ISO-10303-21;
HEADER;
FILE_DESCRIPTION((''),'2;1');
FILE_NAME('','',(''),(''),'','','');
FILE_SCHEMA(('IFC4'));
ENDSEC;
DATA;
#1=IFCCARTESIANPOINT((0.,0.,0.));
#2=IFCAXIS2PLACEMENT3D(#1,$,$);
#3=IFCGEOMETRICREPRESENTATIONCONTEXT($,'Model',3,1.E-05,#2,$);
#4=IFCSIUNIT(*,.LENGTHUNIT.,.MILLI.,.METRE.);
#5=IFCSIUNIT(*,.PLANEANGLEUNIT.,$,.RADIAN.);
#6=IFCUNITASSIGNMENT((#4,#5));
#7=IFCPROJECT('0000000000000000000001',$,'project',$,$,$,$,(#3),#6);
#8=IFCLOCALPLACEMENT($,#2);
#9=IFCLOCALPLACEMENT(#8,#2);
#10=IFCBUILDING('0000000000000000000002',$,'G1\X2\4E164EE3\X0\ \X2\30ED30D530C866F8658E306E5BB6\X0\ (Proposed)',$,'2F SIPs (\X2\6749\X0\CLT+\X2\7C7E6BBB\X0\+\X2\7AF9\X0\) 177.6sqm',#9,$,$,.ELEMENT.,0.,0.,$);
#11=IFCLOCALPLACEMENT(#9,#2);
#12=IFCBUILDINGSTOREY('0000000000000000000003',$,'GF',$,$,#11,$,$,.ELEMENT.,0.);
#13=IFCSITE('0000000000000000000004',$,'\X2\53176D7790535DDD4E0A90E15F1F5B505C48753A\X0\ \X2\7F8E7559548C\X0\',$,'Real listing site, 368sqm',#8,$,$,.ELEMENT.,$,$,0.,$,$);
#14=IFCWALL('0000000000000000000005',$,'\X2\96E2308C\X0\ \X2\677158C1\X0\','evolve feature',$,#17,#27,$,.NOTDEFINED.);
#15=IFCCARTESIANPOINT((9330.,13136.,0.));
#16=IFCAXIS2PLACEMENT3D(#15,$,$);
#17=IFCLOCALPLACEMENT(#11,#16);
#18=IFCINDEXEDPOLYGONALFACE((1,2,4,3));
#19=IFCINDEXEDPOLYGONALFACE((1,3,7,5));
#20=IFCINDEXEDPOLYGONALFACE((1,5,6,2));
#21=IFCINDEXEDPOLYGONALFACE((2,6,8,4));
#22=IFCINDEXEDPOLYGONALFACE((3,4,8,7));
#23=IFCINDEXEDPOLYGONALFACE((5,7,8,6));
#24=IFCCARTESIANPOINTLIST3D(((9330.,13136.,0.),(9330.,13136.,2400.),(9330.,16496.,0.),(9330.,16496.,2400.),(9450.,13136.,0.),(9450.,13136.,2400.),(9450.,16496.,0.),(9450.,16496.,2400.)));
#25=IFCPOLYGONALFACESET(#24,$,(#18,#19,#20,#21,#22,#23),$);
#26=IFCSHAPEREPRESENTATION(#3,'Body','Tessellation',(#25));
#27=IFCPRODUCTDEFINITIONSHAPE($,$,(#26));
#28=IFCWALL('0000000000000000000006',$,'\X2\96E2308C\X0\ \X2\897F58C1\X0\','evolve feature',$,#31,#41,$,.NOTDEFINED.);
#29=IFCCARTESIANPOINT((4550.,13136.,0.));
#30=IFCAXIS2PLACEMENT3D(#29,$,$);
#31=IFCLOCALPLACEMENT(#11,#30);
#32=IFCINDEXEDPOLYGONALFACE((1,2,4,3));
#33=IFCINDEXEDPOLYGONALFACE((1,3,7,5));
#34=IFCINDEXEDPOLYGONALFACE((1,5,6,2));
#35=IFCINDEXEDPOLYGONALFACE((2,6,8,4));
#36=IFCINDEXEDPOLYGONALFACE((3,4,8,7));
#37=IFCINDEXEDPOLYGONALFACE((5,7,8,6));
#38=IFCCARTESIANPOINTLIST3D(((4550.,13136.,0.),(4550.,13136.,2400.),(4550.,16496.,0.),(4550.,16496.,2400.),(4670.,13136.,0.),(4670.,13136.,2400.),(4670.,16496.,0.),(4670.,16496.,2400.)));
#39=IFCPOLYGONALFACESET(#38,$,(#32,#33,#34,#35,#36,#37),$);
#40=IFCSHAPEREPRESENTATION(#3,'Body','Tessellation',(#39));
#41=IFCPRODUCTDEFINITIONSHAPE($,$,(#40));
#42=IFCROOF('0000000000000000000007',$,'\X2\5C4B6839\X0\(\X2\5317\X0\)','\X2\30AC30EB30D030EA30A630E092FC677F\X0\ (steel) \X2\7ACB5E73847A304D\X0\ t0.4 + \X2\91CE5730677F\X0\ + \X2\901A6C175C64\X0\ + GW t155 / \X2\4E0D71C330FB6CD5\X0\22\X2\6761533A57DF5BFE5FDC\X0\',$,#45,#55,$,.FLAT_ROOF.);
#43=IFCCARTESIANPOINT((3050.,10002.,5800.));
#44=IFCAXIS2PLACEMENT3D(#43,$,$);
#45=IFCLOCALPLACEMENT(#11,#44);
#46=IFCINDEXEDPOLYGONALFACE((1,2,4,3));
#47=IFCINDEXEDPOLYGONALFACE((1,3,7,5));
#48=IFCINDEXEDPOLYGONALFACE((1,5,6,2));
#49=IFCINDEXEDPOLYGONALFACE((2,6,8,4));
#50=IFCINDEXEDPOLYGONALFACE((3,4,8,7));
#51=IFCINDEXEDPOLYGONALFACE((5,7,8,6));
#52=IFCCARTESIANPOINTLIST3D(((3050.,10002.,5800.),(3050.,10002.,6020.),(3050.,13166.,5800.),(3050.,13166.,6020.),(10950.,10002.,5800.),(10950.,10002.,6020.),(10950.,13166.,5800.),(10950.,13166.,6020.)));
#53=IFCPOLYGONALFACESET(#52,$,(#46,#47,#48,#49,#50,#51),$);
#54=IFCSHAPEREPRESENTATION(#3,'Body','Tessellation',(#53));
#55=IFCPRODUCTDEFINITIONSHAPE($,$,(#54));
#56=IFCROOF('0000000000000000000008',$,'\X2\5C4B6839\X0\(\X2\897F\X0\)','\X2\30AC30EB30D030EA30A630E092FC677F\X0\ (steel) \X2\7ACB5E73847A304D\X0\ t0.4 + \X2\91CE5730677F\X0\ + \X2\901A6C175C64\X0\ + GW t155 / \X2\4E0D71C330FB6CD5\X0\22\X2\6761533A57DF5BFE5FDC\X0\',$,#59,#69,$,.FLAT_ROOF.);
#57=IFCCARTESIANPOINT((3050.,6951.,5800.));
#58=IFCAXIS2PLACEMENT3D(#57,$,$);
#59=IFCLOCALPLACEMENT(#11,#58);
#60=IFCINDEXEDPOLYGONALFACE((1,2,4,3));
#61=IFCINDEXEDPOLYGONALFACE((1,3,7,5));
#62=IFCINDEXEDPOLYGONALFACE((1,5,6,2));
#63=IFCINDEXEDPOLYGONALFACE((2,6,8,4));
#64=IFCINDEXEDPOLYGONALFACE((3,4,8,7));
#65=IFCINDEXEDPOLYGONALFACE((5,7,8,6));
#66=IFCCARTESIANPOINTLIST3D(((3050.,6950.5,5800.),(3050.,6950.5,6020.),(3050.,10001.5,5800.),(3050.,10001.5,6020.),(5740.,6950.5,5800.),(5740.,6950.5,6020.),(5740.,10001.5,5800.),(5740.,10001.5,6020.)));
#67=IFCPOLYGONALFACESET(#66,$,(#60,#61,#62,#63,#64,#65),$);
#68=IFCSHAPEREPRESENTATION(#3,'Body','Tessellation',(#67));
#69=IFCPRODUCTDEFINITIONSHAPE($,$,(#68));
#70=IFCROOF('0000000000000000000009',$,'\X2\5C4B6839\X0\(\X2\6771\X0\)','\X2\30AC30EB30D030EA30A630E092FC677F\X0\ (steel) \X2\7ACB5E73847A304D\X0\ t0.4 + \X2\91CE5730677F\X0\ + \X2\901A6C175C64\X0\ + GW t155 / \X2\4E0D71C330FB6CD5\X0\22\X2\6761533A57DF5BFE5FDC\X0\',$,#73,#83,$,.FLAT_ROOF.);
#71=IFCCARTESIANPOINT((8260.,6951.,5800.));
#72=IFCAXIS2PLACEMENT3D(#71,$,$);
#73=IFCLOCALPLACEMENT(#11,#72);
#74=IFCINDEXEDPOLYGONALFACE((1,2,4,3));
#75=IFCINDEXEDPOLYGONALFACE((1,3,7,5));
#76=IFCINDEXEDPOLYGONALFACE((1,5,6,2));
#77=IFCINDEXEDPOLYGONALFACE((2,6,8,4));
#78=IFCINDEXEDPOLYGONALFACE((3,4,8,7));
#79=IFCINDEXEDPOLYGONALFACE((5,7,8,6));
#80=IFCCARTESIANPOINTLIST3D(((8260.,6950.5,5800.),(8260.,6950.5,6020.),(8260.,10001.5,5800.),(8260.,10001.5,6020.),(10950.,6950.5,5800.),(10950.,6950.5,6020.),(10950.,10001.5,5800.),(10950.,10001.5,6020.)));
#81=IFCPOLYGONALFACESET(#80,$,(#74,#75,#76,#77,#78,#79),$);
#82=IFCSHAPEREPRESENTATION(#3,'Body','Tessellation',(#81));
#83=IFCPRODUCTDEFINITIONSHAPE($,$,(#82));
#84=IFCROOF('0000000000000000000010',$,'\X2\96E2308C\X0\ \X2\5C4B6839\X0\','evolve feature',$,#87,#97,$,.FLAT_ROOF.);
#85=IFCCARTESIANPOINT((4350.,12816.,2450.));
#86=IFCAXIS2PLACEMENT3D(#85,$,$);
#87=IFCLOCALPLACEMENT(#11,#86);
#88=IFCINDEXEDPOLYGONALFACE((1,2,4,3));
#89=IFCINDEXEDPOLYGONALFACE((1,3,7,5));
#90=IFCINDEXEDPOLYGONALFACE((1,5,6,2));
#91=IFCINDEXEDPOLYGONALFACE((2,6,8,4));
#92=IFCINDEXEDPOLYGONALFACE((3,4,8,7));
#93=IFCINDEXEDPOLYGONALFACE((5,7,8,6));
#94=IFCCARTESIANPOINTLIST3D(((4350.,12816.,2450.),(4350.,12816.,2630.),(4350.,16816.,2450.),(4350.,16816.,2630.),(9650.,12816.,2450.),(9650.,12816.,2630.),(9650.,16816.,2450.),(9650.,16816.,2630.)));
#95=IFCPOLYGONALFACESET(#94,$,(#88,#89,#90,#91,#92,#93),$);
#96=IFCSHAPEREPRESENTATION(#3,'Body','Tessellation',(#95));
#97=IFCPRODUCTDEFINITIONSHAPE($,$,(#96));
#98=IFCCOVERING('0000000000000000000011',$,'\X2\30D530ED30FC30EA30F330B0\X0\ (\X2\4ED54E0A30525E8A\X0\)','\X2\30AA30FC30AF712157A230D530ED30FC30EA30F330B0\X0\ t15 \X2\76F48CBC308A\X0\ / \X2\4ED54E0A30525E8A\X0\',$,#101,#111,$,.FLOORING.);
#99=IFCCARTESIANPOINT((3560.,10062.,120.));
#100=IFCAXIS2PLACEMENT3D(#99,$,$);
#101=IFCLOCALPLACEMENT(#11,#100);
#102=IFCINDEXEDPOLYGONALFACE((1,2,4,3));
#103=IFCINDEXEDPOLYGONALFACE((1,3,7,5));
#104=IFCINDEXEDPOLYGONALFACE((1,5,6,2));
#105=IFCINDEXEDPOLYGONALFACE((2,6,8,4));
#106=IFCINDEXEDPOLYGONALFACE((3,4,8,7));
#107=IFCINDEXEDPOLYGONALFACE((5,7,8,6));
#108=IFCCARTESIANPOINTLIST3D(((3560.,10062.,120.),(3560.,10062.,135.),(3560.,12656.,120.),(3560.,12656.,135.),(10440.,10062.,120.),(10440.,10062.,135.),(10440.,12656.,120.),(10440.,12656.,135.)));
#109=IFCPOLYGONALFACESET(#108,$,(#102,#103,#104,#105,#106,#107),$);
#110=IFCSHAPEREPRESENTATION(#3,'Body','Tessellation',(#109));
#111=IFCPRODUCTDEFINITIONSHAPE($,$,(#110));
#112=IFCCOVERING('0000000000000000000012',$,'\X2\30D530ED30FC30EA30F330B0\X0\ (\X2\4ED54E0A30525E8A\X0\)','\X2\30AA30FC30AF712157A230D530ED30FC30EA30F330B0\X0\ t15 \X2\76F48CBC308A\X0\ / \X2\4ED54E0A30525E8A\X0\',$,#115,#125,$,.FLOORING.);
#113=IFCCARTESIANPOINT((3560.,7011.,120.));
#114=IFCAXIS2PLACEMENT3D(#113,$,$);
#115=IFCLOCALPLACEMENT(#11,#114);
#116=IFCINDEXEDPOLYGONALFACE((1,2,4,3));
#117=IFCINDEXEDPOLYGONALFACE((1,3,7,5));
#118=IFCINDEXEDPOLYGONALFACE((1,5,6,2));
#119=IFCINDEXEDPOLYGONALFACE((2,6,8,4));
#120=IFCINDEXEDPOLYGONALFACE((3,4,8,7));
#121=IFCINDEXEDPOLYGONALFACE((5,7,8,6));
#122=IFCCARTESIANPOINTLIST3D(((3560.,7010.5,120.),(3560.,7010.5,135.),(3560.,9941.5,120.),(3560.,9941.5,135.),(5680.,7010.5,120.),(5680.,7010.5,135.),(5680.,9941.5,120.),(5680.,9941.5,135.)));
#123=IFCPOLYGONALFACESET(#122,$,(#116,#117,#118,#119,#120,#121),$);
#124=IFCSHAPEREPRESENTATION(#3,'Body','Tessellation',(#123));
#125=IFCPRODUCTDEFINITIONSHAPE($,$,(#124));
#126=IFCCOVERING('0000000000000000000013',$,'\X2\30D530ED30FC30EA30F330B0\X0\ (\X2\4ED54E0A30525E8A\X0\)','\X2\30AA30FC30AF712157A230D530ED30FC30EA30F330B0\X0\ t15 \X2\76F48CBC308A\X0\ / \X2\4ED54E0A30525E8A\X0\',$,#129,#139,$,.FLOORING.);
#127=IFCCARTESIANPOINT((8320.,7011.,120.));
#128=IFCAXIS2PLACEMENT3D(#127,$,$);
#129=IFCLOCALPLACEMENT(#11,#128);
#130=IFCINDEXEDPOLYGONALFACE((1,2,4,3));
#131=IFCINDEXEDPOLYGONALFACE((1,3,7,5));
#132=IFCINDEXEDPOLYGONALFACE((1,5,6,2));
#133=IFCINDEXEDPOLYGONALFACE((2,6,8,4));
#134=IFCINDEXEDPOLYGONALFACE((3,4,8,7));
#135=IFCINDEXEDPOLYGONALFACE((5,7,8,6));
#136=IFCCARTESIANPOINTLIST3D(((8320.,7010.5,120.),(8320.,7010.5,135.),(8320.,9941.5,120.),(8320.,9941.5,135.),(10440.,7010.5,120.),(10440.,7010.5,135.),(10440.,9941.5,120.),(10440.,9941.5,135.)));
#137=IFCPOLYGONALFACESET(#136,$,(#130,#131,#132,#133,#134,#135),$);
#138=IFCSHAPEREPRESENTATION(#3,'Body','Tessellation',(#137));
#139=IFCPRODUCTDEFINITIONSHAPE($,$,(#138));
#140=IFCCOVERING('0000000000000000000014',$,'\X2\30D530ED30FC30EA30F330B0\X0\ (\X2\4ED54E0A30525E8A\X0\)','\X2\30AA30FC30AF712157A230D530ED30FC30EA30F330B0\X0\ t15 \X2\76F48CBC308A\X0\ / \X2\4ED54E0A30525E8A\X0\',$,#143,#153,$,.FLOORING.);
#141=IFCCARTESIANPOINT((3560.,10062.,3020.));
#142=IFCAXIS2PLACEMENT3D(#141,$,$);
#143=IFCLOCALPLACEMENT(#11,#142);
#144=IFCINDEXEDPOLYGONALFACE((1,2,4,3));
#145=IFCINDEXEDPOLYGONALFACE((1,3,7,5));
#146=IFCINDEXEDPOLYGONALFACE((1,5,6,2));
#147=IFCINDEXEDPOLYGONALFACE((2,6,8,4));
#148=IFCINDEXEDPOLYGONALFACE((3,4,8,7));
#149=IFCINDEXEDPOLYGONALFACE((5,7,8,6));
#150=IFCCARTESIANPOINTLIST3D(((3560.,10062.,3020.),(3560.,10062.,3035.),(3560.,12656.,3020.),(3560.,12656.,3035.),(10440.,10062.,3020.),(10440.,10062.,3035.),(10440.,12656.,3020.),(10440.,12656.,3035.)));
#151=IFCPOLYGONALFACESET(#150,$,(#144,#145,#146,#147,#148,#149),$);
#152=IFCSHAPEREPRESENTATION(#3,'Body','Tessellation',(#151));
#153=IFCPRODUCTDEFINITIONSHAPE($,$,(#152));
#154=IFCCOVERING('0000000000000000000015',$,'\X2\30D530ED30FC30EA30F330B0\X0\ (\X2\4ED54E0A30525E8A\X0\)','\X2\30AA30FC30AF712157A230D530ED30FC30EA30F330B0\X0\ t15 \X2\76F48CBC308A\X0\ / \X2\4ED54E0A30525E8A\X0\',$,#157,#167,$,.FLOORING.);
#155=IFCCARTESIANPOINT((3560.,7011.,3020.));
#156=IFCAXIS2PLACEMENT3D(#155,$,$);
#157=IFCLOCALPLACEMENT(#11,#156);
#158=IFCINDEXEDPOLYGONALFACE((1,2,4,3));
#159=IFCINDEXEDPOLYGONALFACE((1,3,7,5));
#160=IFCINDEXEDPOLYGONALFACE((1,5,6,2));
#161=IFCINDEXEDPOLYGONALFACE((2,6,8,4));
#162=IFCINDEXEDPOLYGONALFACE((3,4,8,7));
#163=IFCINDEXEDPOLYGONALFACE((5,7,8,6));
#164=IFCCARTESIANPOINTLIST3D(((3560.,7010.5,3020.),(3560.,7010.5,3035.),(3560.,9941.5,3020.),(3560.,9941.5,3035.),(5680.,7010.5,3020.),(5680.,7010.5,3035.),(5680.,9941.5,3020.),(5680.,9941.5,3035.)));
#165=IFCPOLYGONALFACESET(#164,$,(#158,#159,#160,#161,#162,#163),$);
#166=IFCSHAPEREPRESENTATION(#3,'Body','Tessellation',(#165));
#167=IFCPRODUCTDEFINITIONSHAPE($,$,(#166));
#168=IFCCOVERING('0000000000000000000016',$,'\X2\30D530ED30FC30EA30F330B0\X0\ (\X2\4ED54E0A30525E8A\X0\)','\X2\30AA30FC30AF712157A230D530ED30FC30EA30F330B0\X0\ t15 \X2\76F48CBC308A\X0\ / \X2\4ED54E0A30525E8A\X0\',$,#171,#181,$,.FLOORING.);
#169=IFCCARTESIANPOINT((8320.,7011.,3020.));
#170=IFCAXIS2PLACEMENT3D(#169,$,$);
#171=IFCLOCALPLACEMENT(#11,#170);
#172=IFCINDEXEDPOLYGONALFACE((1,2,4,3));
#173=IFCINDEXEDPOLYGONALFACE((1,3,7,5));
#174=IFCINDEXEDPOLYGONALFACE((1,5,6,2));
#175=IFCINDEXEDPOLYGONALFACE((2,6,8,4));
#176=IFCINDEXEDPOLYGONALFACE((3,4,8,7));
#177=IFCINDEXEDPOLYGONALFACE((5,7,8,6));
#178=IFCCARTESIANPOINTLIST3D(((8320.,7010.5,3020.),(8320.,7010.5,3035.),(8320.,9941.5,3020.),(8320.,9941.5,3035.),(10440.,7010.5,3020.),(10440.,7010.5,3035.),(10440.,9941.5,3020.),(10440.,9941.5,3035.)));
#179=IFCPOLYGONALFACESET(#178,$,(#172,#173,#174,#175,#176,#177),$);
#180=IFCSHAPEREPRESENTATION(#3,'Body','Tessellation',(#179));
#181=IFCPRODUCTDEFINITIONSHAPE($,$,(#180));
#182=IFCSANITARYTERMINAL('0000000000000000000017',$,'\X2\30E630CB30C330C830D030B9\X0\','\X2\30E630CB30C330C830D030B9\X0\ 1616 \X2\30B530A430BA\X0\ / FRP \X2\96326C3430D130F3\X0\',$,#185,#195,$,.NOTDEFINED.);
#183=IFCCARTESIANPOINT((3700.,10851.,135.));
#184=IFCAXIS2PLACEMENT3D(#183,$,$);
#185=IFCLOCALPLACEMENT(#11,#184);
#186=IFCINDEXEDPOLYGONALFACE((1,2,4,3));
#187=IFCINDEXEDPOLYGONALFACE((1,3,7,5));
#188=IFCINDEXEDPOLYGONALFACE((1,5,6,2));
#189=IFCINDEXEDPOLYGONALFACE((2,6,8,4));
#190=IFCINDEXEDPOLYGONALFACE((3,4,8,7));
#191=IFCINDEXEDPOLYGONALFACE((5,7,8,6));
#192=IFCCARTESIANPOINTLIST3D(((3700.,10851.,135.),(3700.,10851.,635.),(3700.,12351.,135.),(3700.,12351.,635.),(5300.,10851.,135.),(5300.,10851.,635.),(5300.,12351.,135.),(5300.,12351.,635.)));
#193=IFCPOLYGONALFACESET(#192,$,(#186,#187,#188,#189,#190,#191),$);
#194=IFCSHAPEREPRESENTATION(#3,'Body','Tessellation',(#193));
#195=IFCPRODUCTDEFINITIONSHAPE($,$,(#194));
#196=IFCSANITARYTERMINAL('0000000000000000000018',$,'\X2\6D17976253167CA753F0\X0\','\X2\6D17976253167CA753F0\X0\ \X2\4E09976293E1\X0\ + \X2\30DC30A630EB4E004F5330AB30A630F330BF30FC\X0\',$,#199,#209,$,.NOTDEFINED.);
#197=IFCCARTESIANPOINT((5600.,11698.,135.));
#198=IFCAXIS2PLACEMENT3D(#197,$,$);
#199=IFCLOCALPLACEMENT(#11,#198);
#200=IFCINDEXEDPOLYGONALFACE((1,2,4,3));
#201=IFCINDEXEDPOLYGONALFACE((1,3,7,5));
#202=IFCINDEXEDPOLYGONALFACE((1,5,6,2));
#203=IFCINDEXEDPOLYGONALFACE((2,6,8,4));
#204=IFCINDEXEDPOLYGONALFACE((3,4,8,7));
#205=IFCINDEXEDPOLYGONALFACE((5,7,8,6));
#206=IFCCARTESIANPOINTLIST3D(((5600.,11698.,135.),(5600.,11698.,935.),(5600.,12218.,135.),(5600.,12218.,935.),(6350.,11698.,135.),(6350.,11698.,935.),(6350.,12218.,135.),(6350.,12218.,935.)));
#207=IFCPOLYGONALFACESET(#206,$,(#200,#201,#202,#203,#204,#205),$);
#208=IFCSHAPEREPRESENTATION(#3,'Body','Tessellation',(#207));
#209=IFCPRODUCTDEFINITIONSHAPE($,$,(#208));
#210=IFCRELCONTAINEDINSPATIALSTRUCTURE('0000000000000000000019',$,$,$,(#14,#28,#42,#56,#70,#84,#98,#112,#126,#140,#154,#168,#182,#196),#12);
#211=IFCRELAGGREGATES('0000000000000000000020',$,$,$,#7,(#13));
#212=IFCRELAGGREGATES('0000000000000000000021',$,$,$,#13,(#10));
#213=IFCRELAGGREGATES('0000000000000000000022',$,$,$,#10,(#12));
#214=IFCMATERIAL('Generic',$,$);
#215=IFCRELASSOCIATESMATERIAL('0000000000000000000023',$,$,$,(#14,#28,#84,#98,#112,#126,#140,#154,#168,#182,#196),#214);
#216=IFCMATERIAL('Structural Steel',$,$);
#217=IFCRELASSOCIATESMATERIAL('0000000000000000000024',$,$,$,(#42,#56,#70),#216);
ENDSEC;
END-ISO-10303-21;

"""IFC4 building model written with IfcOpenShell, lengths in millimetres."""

from ifc_helpers import new_model, si_unit, frame, frame_2d, origin, place, context, project, spatial, rectangle, extrude, material, element, save


model = new_model("IFC4")

# Units and contexts
model_context = context("Model", 3, precision=1e-05, world=origin())
ifc_project = project(units=[si_unit("LENGTHUNIT", "METRE", prefix="MILLI"), si_unit("PLANEANGLEUNIT", "RADIAN")], contexts=[model_context])

# Site, building, storey
site_placement = place(None, origin())
site = spatial("IfcSite", under=ifc_project, at=site_placement, Name="北海道川上郡弟子屈町 美留和", ObjectType="Real listing site, 368sqm", CompositionType="ELEMENT", RefElevation=0.0)
building_placement = place(site_placement, origin())
building = spatial("IfcBuilding", under=site, at=building_placement, Name="G1世代 ロフト書斎の家 (Proposed)", ObjectType="2F SIPs (杉CLT+籾殻+竹) 177.6sqm", CompositionType="ELEMENT", ElevationOfRefHeight=0.0, ElevationOfTerrain=0.0)
storey_placement = place(building_placement, origin())
storey = spatial("IfcBuildingStorey", under=building, at=storey_placement, Name="GF", CompositionType="ELEMENT", Elevation=0.0)

# Shared definitions
ifc_material_1 = material(Name="Generic")

# Walls
wall_1_placement = place(storey_placement, frame((9330.0, 13136.0, 0.0)))
element("IfcWall", 1, at=wall_1_placement, inside=storey, material=ifc_material_1, Name="離れ 東壁", Description="evolve feature", PredefinedType="NOTDEFINED", context=model_context, shape_type="SweptSolid", body=[
    extrude(rectangle(XDim=120.0, YDim=3360.0, at=frame_2d((60.0, 1680.0))), frame((9330.0, 13136.0, 0.0)), (0.0, 0.0, 1.0), 2400.0),
])
wall_2_placement = place(storey_placement, frame((4550.0, 13136.0, 0.0)))
element("IfcWall", 2, at=wall_2_placement, inside=storey, material=ifc_material_1, Name="離れ 西壁", Description="evolve feature", PredefinedType="NOTDEFINED", context=model_context, shape_type="SweptSolid", body=[
    extrude(rectangle(XDim=120.0, YDim=3360.0, at=frame_2d((60.0, 1680.0))), frame((4550.0, 13136.0, 0.0)), (0.0, 0.0, 1.0), 2400.0),
])

# Roofs
ifc_material_2 = material(Name="Structural Steel")
for number, where, name in (
    (3, (3050.0, 10002.0, 5800.0), "屋根(北)"),
):
    element("IfcRoof", number, at=place(storey_placement, frame(where)), inside=storey, material=ifc_material_2, Name=name, Description="ガルバリウム鋼板 (steel) 立平葺き t0.4 + 野地板 + 通気層 + GW t155 / 不燃・法22条区域対応", PredefinedType="FLAT_ROOF", context=model_context, shape_type="SweptSolid", body=[
        extrude(rectangle(XDim=7900.0, YDim=3164.0, at=frame_2d((3950.0, 1582.0))), frame((3050.0, 10002.0, 5800.0)), (0.0, 0.0, 1.0), 220.0),
    ])
roof_1_placement = place(storey_placement, frame((3050.0, 6951.0, 5800.0)))
element("IfcRoof", 4, at=roof_1_placement, inside=storey, material=ifc_material_2, Name="屋根(西)", Description="ガルバリウム鋼板 (steel) 立平葺き t0.4 + 野地板 + 通気層 + GW t155 / 不燃・法22条区域対応", PredefinedType="FLAT_ROOF", context=model_context, shape_type="SweptSolid", body=[
    extrude(rectangle(XDim=2690.0, YDim=3051.0, at=frame_2d((1345.0, 1525.0))), frame((3050.0, 6951.0, 5800.0)), (0.0, 0.0, 1.0), 220.0),
])
roof_2_placement = place(storey_placement, frame((8260.0, 6951.0, 5800.0)))
element("IfcRoof", 5, at=roof_2_placement, inside=storey, material=ifc_material_2, Name="屋根(東)", Description="ガルバリウム鋼板 (steel) 立平葺き t0.4 + 野地板 + 通気層 + GW t155 / 不燃・法22条区域対応", PredefinedType="FLAT_ROOF", context=model_context, shape_type="SweptSolid", body=[
    extrude(rectangle(XDim=2690.0, YDim=3051.0, at=frame_2d((1345.0, 1525.0))), frame((8260.0, 6951.0, 5800.0)), (0.0, 0.0, 1.0), 220.0),
])
roof_3_placement = place(storey_placement, frame((4350.0, 12816.0, 2450.0)))
element("IfcRoof", 6, at=roof_3_placement, inside=storey, material=ifc_material_1, Name="離れ 屋根", Description="evolve feature", PredefinedType="FLAT_ROOF", context=model_context, shape_type="SweptSolid", body=[
    extrude(rectangle(XDim=5300.0, YDim=4000.0, at=frame_2d((2650.0, 2000.0))), frame((4350.0, 12816.0, 2450.0)), (0.0, 0.0, 1.0), 180.0),
])

# Coverings
covering_1_placement = place(storey_placement, frame((3560.0, 10062.0, 120.0)))
element("IfcCovering", 7, at=covering_1_placement, inside=storey, material=ifc_material_1, Name="フローリング (仕上げ床)", Description="オーク無垢フローリング t15 直貼り / 仕上げ床", PredefinedType="FLOORING", context=model_context, shape_type="SweptSolid", body=[
    extrude(rectangle(XDim=6880.0, YDim=2594.0, at=frame_2d((3440.0, 1297.0))), frame((3560.0, 10062.0, 120.0)), (0.0, 0.0, 1.0), 15.0),
])
covering_2_placement = place(storey_placement, frame((3560.0, 7011.0, 120.0)))
element("IfcCovering", 8, at=covering_2_placement, inside=storey, material=ifc_material_1, Name="フローリング (仕上げ床)", Description="オーク無垢フローリング t15 直貼り / 仕上げ床", PredefinedType="FLOORING", context=model_context, shape_type="SweptSolid", body=[
    extrude(rectangle(XDim=2120.0, YDim=2931.0, at=frame_2d((1060.0, 1465.0))), frame((3560.0, 7011.0, 120.0)), (0.0, 0.0, 1.0), 15.0),
])
covering_3_placement = place(storey_placement, frame((8320.0, 7011.0, 120.0)))
element("IfcCovering", 9, at=covering_3_placement, inside=storey, material=ifc_material_1, Name="フローリング (仕上げ床)", Description="オーク無垢フローリング t15 直貼り / 仕上げ床", PredefinedType="FLOORING", context=model_context, shape_type="SweptSolid", body=[
    extrude(rectangle(XDim=2120.0, YDim=2931.0, at=frame_2d((1060.0, 1465.0))), frame((8320.0, 7011.0, 120.0)), (0.0, 0.0, 1.0), 15.0),
])
covering_4_placement = place(storey_placement, frame((3560.0, 10062.0, 3020.0)))
element("IfcCovering", 10, at=covering_4_placement, inside=storey, material=ifc_material_1, Name="フローリング (仕上げ床)", Description="オーク無垢フローリング t15 直貼り / 仕上げ床", PredefinedType="FLOORING", context=model_context, shape_type="SweptSolid", body=[
    extrude(rectangle(XDim=6880.0, YDim=2594.0, at=frame_2d((3440.0, 1297.0))), frame((3560.0, 10062.0, 3020.0)), (0.0, 0.0, 1.0), 15.0),
])
covering_5_placement = place(storey_placement, frame((3560.0, 7011.0, 3020.0)))
element("IfcCovering", 11, at=covering_5_placement, inside=storey, material=ifc_material_1, Name="フローリング (仕上げ床)", Description="オーク無垢フローリング t15 直貼り / 仕上げ床", PredefinedType="FLOORING", context=model_context, shape_type="SweptSolid", body=[
    extrude(rectangle(XDim=2120.0, YDim=2931.0, at=frame_2d((1060.0, 1465.0))), frame((3560.0, 7011.0, 3020.0)), (0.0, 0.0, 1.0), 15.0),
])
covering_6_placement = place(storey_placement, frame((8320.0, 7011.0, 3020.0)))
element("IfcCovering", 12, at=covering_6_placement, inside=storey, material=ifc_material_1, Name="フローリング (仕上げ床)", Description="オーク無垢フローリング t15 直貼り / 仕上げ床", PredefinedType="FLOORING", context=model_context, shape_type="SweptSolid", body=[
    extrude(rectangle(XDim=2120.0, YDim=2931.0, at=frame_2d((1060.0, 1465.0))), frame((8320.0, 7011.0, 3020.0)), (0.0, 0.0, 1.0), 15.0),
])

# Sanitary terminals
sanitary_terminal_1_placement = place(storey_placement, frame((3700.0, 10851.0, 135.0)))
element("IfcSanitaryTerminal", 13, at=sanitary_terminal_1_placement, inside=storey, material=ifc_material_1, Name="ユニットバス", Description="ユニットバス 1616 サイズ / FRP 防水パン", PredefinedType="NOTDEFINED", context=model_context, shape_type="SweptSolid", body=[
    extrude(rectangle(XDim=1600.0, YDim=1500.0, at=frame_2d((800.0, 750.0))), frame((3700.0, 10851.0, 135.0)), (0.0, 0.0, 1.0), 500.0),
])
sanitary_terminal_2_placement = place(storey_placement, frame((5600.0, 11698.0, 135.0)))
element("IfcSanitaryTerminal", 14, at=sanitary_terminal_2_placement, inside=storey, material=ifc_material_1, Name="洗面化粧台", Description="洗面化粧台 三面鏡 + ボウル一体カウンター", PredefinedType="NOTDEFINED", context=model_context, shape_type="SweptSolid", body=[
    extrude(rectangle(XDim=750.0, YDim=520.0, at=frame_2d((375.0, 260.0))), frame((5600.0, 11698.0, 135.0)), (0.0, 0.0, 1.0), 800.0),
])

save(model, "model.ifc")
